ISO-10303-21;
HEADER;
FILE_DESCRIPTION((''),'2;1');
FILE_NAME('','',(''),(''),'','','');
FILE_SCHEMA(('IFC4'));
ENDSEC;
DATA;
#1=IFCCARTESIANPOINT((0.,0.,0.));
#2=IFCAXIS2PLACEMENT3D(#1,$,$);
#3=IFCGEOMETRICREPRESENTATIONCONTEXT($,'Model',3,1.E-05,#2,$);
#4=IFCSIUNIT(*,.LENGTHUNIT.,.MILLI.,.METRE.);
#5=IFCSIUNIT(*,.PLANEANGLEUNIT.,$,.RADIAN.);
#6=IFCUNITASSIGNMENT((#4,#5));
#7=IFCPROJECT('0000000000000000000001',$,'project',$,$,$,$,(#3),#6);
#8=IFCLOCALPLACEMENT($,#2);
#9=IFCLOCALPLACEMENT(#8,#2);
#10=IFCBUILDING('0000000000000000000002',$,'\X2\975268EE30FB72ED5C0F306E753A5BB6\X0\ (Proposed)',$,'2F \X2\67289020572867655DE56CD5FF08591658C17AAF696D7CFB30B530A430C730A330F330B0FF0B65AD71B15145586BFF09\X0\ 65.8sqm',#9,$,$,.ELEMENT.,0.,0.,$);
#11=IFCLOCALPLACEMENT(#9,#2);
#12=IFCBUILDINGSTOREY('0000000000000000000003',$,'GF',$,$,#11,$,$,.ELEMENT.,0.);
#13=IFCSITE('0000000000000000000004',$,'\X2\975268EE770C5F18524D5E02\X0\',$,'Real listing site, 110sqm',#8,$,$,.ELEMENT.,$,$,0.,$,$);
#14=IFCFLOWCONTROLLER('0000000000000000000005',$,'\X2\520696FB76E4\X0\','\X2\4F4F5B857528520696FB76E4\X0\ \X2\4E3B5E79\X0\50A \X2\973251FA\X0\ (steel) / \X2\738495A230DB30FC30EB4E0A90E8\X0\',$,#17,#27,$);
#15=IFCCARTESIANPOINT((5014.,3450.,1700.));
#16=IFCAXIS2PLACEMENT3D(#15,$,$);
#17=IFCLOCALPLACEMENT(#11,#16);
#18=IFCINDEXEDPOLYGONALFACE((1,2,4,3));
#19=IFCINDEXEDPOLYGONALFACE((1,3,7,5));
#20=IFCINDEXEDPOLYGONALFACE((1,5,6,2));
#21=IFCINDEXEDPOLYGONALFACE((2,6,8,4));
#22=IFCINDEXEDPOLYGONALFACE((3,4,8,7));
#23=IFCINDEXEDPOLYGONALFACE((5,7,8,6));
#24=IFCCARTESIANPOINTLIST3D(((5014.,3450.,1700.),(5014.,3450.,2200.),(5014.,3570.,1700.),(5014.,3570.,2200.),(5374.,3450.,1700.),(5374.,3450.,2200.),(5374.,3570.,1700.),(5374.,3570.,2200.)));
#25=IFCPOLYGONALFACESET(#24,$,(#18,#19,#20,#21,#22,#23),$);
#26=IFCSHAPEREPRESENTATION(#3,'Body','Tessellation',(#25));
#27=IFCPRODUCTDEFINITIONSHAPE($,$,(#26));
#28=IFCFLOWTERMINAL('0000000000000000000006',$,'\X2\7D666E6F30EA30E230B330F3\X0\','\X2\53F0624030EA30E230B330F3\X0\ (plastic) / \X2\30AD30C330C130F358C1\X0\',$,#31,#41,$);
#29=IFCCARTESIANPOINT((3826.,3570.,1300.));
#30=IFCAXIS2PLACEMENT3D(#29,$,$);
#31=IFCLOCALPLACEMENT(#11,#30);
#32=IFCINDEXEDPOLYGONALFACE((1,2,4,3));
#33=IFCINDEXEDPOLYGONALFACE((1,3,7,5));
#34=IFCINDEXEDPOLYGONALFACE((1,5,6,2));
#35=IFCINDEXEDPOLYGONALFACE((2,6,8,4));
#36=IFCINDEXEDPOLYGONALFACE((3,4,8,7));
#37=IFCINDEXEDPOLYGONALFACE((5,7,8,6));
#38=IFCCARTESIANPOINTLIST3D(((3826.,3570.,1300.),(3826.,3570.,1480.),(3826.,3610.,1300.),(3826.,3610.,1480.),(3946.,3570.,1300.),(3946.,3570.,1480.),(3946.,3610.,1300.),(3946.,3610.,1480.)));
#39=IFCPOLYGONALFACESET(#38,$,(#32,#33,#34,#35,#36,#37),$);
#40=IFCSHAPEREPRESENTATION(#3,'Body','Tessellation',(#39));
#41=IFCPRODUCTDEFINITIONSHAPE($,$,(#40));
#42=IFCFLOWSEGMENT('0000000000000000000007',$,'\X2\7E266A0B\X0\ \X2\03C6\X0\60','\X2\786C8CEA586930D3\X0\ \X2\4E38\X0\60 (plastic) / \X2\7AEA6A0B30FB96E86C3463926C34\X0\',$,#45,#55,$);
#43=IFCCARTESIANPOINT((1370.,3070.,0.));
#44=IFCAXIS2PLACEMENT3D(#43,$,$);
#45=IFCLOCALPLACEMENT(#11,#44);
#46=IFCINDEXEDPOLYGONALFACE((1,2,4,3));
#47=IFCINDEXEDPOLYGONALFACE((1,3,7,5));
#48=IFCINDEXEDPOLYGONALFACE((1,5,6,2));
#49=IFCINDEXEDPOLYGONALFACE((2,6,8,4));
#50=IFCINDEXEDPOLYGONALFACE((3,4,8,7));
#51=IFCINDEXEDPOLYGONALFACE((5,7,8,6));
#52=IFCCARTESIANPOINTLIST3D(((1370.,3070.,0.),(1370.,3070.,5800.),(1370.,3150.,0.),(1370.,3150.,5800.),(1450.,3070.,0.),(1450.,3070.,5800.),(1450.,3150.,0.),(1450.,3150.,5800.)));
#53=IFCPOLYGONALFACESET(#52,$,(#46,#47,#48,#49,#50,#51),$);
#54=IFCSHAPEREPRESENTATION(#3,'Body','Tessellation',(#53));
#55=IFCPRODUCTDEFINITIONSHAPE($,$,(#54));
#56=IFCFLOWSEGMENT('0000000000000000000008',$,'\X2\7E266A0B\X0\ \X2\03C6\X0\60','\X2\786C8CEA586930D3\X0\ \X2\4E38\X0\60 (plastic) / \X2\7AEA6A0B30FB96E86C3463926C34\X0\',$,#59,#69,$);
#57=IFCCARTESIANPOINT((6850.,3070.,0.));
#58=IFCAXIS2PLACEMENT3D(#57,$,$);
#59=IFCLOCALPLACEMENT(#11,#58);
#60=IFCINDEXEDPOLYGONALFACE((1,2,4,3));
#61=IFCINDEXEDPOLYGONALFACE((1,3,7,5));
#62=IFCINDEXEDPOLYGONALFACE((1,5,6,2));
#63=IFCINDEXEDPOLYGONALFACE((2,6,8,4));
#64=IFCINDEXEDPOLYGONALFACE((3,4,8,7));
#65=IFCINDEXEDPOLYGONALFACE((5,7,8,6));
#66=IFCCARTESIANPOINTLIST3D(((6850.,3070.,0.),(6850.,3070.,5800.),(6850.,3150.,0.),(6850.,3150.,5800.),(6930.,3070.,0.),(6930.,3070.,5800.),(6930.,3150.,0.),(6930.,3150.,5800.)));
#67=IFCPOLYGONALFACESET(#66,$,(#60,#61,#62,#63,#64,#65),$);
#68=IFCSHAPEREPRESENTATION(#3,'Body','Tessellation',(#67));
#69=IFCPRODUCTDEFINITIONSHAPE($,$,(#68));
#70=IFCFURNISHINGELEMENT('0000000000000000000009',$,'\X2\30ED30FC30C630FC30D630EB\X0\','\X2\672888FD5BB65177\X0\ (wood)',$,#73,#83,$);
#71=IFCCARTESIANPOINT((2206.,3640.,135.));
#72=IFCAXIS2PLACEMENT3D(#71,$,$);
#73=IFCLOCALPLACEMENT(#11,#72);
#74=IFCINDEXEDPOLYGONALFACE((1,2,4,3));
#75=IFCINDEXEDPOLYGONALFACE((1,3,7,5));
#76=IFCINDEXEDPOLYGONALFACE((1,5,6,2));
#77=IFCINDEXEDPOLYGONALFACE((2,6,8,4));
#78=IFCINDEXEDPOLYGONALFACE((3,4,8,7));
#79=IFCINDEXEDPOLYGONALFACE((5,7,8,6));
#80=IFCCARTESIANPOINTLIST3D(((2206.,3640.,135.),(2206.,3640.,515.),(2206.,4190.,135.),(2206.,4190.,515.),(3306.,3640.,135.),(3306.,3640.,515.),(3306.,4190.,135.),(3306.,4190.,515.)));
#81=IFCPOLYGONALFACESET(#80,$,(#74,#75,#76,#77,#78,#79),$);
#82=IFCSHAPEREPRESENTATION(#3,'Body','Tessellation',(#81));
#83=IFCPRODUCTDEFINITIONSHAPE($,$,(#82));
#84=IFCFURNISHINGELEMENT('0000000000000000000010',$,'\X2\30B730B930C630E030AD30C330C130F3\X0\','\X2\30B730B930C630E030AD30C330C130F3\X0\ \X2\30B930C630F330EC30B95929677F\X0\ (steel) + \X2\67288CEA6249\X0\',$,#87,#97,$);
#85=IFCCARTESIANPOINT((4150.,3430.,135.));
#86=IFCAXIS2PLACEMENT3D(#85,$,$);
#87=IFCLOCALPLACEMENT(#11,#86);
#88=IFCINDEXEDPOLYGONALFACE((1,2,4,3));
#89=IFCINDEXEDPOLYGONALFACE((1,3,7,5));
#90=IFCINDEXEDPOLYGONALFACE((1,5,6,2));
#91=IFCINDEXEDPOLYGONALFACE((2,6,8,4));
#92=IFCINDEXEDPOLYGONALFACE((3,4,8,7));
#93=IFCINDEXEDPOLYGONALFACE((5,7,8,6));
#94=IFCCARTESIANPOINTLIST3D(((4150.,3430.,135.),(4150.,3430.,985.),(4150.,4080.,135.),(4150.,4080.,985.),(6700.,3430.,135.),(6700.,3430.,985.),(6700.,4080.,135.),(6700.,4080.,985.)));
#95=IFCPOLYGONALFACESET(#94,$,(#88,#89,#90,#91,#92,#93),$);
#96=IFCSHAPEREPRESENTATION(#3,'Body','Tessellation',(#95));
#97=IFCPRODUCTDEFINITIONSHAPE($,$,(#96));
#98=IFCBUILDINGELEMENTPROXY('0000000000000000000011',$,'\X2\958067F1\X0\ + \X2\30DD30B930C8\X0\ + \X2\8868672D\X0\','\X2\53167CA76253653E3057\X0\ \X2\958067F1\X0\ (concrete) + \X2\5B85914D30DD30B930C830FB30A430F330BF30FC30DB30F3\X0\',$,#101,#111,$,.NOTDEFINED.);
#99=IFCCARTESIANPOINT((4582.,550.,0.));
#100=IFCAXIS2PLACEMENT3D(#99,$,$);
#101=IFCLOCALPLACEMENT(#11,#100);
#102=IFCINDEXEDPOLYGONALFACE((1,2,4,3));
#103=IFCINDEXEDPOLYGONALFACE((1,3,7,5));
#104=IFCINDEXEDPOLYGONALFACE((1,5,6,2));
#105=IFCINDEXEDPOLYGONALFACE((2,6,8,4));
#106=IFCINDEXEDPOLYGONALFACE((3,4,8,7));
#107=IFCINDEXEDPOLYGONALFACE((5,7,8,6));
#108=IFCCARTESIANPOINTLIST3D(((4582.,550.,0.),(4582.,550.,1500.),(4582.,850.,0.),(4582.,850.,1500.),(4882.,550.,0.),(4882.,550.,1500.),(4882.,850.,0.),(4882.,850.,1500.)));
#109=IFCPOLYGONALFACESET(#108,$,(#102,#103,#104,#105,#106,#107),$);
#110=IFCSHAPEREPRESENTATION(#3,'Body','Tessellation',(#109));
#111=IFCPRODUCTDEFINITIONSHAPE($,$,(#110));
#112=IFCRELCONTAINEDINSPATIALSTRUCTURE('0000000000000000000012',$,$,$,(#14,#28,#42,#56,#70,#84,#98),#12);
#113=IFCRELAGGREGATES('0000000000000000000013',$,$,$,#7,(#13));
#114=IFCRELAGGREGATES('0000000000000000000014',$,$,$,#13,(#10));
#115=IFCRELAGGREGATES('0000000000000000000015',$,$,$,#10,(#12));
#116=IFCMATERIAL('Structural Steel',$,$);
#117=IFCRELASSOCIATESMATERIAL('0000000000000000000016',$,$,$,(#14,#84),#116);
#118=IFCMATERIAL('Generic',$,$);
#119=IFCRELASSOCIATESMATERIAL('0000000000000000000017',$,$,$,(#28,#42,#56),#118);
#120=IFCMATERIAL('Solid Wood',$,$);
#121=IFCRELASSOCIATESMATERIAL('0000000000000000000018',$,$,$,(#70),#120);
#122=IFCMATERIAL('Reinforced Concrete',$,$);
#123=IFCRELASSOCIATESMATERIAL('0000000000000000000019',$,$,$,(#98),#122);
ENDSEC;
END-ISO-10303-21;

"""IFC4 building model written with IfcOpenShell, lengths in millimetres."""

from ifc_helpers import new_model, si_unit, frame, frame_2d, origin, place, context, project, spatial, rectangle, extrude, material, element, save


model = new_model("IFC4")

# Units and contexts
model_context = context("Model", 3, precision=1e-05, world=origin())
ifc_project = project(units=[si_unit("LENGTHUNIT", "METRE", prefix="MILLI"), si_unit("PLANEANGLEUNIT", "RADIAN")], contexts=[model_context])

# Site, building, storey
site_placement = place(None, origin())
site = spatial("IfcSite", under=ifc_project, at=site_placement, Name="青森県弘前市", ObjectType="Real listing site, 110sqm", CompositionType="ELEMENT", RefElevation=0.0)
building_placement = place(site_placement, origin())
building = spatial("IfcBuilding", under=site, at=building_placement, Name="青森・狭小の町家 (Proposed)", ObjectType="2F 木造在来工法（外壁窯業系サイディング＋断熱充填） 65.8sqm", CompositionType="ELEMENT", ElevationOfRefHeight=0.0, ElevationOfTerrain=0.0)
storey_placement = place(building_placement, origin())
storey = spatial("IfcBuildingStorey", under=building, at=storey_placement, Name="GF", CompositionType="ELEMENT", Elevation=0.0)

# Shared definitions
ifc_material_1 = material(Name="Solid Wood")

# Shared definitions
ifc_material_2 = material(Name="Reinforced Concrete")

# Shared definitions
ifc_material_3 = material(Name="Generic")

# Flow controller
ifc_material_4 = material(Name="Structural Steel")
flow_controller_placement = place(storey_placement, frame((5014.0, 3450.0, 1700.0)))
element("IfcFlowController", 1, at=flow_controller_placement, inside=storey, material=ifc_material_4, Name="分電盤", Description="住宅用分電盤 主幹50A 露出 (steel) / 玄関ホール上部", context=model_context, shape_type="SweptSolid", body=[
    extrude(rectangle(XDim=360.0, YDim=120.0, at=frame_2d((180.0, 60.0))), frame((5014.0, 3450.0, 1700.0)), (0.0, 0.0, 1.0), 500.0),
])

# Flow terminal
flow_terminal_placement = place(storey_placement, frame((3826.0, 3570.0, 1300.0)))
element("IfcFlowTerminal", 2, at=flow_terminal_placement, inside=storey, material=ifc_material_3, Name="給湯リモコン", Description="台所リモコン (plastic) / キッチン壁", context=model_context, shape_type="SweptSolid", body=[
    extrude(rectangle(XDim=120.0, YDim=40.0, at=frame_2d((60.0, 20.0))), frame((3826.0, 3570.0, 1300.0)), (0.0, 0.0, 1.0), 180.0),
])

# Flow segments
flow_segment_1_placement = place(storey_placement, frame((1370.0, 3070.0, 0.0)))
element("IfcFlowSegment", 3, at=flow_segment_1_placement, inside=storey, material=ifc_material_3, Name="縦樋 φ60", Description="硬質塩ビ 丸60 (plastic) / 竪樋・雨水排水", context=model_context, shape_type="SweptSolid", body=[
    extrude(rectangle(XDim=80.0, YDim=80.0, at=frame_2d((40.0, 40.0))), frame((1370.0, 3070.0, 0.0)), (0.0, 0.0, 1.0), 5800.0),
])
flow_segment_2_placement = place(storey_placement, frame((6850.0, 3070.0, 0.0)))
element("IfcFlowSegment", 4, at=flow_segment_2_placement, inside=storey, material=ifc_material_3, Name="縦樋 φ60", Description="硬質塩ビ 丸60 (plastic) / 竪樋・雨水排水", context=model_context, shape_type="SweptSolid", body=[
    extrude(rectangle(XDim=80.0, YDim=80.0, at=frame_2d((40.0, 40.0))), frame((6850.0, 3070.0, 0.0)), (0.0, 0.0, 1.0), 5800.0),
])

# Furnishing elements
furnishing_1_placement = place(storey_placement, frame((2206.0, 3640.0, 135.0)))
element("IfcFurnishingElement", 5, at=furnishing_1_placement, inside=storey, material=ifc_material_1, Name="ローテーブル", Description="木製家具 (wood)", context=model_context, shape_type="SweptSolid", body=[
    extrude(rectangle(XDim=1100.0, YDim=550.0, at=frame_2d((550.0, 275.0))), frame((2206.0, 3640.0, 135.0)), (0.0, 0.0, 1.0), 380.0),
])
furnishing_2_placement = place(storey_placement, frame((4150.0, 3430.0, 135.0)))
element("IfcFurnishingElement", 6, at=furnishing_2_placement, inside=storey, material=ifc_material_4, Name="システムキッチン", Description="システムキッチン ステンレス天板 (steel) + 木質扉", context=model_context, shape_type="SweptSolid", body=[
    extrude(rectangle(XDim=2550.0, YDim=650.0, at=frame_2d((1275.0, 325.0))), frame((4150.0, 3430.0, 135.0)), (0.0, 0.0, 1.0), 850.0),
])

# Building element proxy
proxy_placement = place(storey_placement, frame((4582.0, 550.0, 0.0)))
element("IfcBuildingElementProxy", 7, at=proxy_placement, inside=storey, material=ifc_material_2, Name="門柱 + ポスト + 表札", Description="化粧打放し 門柱 (concrete) + 宅配ポスト・インターホン", PredefinedType="NOTDEFINED", context=model_context, shape_type="SweptSolid", body=[
    extrude(rectangle(XDim=300.0, YDim=300.0, at=frame_2d((150.0, 150.0))), frame((4582.0, 550.0, 0.0)), (0.0, 0.0, 1.0), 1500.0),
])

save(model, "model.ifc")
